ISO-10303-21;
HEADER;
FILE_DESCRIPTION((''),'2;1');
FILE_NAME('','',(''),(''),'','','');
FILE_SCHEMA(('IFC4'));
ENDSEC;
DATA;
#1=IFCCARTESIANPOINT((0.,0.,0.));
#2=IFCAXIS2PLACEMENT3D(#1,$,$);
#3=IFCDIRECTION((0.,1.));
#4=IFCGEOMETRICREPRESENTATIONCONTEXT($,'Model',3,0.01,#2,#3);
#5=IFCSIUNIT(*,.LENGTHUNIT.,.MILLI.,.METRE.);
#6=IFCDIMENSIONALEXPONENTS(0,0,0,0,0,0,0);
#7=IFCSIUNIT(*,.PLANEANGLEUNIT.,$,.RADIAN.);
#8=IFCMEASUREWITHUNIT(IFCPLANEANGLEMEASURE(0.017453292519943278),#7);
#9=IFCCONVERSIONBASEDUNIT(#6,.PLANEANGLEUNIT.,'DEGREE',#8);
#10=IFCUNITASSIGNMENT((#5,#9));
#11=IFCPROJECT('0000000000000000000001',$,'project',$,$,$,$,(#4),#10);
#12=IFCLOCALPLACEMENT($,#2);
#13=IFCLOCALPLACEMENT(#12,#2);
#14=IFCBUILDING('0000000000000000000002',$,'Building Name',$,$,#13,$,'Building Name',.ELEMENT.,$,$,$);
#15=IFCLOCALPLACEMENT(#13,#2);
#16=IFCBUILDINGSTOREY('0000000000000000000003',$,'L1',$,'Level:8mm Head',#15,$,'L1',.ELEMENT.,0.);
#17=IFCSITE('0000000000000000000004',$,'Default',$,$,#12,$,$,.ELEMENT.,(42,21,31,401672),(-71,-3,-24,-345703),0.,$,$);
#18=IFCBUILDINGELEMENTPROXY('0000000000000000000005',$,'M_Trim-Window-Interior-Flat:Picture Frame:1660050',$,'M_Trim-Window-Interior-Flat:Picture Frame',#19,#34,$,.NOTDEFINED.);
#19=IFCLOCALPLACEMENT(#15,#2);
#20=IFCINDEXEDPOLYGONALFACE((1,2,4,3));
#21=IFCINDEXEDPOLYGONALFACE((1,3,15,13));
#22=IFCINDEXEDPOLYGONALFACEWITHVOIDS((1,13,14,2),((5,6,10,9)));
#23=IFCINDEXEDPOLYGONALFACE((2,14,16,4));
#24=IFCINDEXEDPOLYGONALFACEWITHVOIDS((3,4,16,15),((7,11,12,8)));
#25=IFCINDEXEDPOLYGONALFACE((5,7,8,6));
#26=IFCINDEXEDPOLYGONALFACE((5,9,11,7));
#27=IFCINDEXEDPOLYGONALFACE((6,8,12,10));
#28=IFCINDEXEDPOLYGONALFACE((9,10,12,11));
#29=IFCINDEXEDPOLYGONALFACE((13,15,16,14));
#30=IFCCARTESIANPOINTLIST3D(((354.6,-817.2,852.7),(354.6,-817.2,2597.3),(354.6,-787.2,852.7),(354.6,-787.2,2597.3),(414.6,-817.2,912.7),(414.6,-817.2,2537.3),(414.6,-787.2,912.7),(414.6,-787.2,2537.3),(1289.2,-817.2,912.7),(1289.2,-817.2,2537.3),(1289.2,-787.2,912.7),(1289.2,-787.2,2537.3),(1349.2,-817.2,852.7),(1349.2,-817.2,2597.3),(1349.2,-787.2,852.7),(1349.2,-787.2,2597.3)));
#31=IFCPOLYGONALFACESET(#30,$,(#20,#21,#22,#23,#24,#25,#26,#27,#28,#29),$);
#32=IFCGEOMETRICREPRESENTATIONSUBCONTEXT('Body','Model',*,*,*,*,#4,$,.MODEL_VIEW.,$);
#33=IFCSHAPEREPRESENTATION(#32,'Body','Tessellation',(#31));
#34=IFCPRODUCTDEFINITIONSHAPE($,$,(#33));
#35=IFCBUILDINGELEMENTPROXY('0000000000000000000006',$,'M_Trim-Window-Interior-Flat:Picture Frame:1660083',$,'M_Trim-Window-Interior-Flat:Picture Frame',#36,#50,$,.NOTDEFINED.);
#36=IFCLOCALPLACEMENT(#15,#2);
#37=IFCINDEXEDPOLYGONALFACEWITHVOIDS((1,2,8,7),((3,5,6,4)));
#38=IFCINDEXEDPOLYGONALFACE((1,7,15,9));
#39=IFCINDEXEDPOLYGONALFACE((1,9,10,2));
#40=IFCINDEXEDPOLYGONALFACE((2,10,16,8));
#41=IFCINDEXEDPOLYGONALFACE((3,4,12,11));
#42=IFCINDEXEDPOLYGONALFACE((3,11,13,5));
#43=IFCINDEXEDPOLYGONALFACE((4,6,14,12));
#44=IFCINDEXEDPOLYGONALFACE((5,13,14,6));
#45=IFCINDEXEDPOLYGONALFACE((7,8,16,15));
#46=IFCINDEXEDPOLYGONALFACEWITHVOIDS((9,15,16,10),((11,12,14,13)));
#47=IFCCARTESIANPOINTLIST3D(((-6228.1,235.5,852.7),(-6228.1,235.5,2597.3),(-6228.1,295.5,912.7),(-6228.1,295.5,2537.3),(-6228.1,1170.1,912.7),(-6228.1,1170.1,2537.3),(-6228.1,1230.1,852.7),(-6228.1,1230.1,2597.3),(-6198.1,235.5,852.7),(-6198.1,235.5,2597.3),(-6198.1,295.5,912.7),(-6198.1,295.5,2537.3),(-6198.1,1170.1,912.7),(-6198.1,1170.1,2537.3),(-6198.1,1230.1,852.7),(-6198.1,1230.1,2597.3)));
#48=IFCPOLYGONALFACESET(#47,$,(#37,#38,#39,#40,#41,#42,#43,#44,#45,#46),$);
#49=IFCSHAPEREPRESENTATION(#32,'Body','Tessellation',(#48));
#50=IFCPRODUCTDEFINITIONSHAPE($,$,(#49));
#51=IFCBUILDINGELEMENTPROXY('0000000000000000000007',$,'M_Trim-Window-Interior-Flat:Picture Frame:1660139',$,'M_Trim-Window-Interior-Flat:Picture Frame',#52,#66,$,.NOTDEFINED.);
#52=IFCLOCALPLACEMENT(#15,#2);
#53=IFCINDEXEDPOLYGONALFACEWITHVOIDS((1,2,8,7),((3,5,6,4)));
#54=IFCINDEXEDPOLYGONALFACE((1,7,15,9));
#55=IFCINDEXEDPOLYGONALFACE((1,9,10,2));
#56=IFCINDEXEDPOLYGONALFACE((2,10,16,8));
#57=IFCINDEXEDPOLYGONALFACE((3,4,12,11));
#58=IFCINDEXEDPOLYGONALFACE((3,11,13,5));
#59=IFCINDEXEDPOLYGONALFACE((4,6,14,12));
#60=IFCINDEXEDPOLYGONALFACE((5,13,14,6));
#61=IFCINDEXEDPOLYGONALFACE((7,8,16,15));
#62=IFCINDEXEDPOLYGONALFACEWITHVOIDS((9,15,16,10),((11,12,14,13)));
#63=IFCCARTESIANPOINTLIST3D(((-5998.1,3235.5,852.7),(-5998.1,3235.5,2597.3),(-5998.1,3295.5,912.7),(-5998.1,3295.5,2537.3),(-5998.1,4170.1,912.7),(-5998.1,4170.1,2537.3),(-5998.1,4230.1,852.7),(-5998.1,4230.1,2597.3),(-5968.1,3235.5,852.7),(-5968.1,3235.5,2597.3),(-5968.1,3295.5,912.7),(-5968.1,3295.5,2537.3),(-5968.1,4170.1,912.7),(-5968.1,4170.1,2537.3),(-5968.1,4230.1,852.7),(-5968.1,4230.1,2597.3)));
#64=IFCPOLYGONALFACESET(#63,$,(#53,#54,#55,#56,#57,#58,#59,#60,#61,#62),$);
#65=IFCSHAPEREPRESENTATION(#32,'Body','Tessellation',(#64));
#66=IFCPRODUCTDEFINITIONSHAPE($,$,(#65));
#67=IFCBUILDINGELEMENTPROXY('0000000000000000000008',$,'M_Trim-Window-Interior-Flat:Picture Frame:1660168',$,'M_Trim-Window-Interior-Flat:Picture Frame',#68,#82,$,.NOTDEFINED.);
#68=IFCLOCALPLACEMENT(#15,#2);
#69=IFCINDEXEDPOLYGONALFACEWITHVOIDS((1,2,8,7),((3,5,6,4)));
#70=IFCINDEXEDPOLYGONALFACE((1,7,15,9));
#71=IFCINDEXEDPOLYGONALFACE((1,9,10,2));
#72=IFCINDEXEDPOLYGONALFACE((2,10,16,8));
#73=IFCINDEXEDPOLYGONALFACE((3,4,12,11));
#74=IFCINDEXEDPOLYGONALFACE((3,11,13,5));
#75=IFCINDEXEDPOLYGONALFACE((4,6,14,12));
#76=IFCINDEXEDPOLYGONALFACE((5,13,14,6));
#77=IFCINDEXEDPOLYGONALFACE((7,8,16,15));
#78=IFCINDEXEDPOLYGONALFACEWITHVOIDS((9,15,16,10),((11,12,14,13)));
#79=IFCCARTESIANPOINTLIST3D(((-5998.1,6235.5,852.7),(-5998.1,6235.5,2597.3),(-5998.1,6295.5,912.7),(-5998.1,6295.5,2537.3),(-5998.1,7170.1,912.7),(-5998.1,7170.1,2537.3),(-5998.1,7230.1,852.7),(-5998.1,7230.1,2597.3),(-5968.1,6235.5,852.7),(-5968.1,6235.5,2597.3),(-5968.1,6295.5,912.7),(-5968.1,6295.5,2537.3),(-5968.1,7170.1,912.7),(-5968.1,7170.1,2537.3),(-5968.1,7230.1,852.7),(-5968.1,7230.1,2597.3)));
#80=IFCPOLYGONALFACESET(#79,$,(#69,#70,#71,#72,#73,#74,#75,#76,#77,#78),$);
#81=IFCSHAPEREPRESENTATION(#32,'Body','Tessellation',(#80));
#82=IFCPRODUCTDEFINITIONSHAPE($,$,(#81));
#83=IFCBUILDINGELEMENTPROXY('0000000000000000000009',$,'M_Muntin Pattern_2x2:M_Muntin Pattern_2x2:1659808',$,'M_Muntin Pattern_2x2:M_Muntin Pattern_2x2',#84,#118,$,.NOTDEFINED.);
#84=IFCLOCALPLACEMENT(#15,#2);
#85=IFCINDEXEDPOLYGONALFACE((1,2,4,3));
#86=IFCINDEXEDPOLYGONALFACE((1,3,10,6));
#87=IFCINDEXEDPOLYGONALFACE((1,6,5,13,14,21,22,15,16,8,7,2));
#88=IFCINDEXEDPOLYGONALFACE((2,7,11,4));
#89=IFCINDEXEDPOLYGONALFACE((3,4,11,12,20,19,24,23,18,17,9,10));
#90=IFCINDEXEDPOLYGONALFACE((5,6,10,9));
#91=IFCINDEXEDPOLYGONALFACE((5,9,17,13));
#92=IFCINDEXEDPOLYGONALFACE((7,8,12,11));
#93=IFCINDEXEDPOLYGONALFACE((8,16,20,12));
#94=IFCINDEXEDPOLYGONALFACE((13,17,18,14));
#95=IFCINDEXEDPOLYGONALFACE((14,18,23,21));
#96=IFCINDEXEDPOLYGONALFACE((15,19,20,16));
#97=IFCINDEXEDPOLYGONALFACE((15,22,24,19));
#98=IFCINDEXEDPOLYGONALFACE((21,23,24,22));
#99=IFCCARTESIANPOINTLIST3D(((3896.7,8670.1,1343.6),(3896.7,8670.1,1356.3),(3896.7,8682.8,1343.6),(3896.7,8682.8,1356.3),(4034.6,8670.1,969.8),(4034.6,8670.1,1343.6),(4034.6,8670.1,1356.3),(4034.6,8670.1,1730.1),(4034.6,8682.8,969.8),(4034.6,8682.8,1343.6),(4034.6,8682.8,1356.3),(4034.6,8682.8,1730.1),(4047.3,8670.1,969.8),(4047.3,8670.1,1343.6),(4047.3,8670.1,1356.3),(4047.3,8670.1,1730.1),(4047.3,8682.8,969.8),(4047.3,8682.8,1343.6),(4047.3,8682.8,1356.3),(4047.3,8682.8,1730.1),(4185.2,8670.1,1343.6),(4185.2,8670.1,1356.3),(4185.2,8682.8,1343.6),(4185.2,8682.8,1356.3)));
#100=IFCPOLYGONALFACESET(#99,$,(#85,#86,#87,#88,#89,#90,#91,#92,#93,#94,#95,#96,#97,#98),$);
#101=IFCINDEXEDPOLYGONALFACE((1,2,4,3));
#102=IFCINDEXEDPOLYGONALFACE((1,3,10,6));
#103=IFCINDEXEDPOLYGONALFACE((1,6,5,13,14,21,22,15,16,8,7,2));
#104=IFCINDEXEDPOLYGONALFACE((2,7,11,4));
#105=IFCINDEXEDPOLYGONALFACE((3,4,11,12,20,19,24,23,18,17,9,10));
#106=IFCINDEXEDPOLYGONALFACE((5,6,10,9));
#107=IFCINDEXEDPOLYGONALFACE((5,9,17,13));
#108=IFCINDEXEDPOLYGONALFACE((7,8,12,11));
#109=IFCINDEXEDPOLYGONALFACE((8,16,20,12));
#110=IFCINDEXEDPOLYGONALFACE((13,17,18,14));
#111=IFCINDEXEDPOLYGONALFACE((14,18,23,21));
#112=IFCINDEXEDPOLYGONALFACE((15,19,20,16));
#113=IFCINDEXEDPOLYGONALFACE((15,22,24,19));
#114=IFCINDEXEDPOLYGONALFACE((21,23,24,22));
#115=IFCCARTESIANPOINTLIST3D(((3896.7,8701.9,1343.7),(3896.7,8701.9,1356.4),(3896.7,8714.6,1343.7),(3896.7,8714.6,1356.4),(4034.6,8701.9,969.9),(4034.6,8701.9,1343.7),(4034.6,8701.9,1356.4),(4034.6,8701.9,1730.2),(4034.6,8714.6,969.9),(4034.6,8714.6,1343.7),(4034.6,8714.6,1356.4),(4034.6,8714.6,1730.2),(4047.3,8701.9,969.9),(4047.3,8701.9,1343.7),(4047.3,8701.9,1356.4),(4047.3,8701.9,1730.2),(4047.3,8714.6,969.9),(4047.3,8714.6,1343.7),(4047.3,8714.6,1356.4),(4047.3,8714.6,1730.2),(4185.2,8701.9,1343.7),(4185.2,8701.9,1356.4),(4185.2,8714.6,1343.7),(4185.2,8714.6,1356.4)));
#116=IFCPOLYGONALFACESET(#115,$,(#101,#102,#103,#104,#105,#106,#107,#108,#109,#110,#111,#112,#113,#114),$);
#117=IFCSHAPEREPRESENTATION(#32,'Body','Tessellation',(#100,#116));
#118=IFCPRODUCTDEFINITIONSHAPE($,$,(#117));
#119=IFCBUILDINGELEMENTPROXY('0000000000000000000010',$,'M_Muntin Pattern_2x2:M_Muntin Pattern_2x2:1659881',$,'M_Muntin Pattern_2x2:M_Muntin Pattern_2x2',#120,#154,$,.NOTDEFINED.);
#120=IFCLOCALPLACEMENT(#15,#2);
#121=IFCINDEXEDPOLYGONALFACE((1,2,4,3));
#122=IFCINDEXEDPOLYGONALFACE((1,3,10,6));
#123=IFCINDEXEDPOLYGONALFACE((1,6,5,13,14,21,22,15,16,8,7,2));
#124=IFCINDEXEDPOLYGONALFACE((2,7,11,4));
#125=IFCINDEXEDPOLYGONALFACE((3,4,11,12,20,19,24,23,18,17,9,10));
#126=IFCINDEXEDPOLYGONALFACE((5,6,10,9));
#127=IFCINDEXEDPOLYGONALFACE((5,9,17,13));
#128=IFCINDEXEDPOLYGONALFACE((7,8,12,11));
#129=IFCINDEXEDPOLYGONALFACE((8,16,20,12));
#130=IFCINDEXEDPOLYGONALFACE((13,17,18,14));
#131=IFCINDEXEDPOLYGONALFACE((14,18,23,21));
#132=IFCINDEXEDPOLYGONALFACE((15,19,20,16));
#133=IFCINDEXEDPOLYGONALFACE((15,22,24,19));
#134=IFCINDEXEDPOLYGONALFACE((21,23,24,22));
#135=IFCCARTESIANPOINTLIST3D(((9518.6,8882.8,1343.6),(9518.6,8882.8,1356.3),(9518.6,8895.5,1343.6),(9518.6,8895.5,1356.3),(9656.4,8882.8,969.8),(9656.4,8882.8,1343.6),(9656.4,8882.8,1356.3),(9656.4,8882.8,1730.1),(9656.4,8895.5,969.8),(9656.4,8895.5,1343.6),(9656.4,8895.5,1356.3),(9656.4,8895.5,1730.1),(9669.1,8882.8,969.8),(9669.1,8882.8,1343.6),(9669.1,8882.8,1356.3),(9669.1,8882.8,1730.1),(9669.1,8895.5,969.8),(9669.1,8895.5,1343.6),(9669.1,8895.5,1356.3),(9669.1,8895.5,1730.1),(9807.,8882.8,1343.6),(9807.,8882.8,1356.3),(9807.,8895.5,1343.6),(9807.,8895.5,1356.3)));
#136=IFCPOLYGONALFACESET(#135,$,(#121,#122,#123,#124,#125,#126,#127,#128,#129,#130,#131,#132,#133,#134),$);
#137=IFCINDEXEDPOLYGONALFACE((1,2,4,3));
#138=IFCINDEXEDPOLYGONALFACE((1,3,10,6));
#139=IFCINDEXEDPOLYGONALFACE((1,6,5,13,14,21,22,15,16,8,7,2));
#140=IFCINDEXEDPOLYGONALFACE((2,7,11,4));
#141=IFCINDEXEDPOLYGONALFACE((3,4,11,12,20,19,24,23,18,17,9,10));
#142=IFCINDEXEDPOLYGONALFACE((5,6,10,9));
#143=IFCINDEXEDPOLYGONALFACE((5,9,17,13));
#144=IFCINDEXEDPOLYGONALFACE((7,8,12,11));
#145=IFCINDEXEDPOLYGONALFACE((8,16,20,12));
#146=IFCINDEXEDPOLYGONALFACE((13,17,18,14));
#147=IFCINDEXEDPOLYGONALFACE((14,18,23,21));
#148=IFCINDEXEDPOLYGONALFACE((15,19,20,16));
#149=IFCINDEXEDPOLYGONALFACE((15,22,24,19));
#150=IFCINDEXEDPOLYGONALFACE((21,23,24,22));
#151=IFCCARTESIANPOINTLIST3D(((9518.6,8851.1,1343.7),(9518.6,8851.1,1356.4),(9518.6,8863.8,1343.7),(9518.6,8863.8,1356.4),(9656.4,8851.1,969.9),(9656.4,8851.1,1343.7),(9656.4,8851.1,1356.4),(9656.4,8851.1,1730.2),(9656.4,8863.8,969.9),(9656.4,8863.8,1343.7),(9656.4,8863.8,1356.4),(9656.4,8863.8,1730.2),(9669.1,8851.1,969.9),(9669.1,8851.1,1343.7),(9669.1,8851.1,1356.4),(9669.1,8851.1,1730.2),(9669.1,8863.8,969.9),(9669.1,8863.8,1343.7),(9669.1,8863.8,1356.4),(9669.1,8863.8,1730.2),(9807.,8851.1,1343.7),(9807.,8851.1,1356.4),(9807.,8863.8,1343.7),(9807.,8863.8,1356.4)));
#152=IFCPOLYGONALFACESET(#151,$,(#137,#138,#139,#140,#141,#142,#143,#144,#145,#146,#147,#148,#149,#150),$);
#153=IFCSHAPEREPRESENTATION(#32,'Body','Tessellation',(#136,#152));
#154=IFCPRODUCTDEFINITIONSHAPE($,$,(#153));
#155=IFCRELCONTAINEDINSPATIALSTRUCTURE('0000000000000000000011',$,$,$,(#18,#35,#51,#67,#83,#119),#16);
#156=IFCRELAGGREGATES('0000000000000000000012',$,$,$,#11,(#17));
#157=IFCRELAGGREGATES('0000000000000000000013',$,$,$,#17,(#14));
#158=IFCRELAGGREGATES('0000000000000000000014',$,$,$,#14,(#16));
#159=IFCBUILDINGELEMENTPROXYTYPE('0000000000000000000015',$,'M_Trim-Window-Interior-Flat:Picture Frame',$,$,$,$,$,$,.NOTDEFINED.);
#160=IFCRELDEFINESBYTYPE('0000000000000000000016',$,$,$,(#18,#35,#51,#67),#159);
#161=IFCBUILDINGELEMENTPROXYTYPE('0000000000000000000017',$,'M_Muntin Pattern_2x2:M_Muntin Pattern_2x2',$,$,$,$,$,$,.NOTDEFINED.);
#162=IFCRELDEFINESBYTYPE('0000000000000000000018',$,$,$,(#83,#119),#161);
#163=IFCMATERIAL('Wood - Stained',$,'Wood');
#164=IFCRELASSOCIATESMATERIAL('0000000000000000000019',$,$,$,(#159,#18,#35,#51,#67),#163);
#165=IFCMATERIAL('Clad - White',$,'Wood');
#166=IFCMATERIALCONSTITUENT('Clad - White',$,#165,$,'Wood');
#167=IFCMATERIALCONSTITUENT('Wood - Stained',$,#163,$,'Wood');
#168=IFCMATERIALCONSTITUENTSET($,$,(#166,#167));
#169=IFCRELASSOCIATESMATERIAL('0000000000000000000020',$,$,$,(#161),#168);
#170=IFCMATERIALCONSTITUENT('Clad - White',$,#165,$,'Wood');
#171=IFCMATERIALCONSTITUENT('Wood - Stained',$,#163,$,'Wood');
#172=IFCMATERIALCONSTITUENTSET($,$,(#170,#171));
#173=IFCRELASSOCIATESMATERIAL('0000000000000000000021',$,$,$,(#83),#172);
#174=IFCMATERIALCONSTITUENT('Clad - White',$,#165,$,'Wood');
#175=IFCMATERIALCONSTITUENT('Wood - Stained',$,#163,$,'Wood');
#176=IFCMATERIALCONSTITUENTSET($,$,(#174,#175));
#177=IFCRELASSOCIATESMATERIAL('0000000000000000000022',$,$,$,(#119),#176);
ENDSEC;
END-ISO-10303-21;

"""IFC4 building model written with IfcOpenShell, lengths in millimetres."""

from ifc_helpers import new_model, entity, si_unit, converted_unit, direction, frame, origin, place, context, subcontext, project, spatial, indexed_curve, outline, extrude, source, transform, mapped, material, constituent, constituent_set, type_object, type_shapes, element, save


model = new_model("IFC4")

# Units and contexts
model_context = context("Model", 3, precision=0.01, world=origin(), true_north=direction((0.0, 1.0)))
body_context = subcontext(model_context, "Body", "Model", "MODEL_VIEW")
ifc_project = project(units=[si_unit("LENGTHUNIT", "METRE", prefix="MILLI"), converted_unit("PLANEANGLEUNIT", "DEGREE", entity("IfcPlaneAngleMeasure", 0.017453292519943278), si_unit("PLANEANGLEUNIT", "RADIAN"), dimensions=[0, 0, 0, 0, 0, 0, 0])], contexts=[model_context])

# Site, building, storey
site_placement = place(None, origin())
site = spatial("IfcSite", under=ifc_project, at=site_placement, Name="Default", CompositionType="ELEMENT", RefLatitude=(42, 21, 31, 401672), RefLongitude=(-71, -3, -24, -345703), RefElevation=0.0)
building_placement = place(site_placement, origin())
building = spatial("IfcBuilding", under=site, at=building_placement, Name="Building Name", LongName="Building Name", CompositionType="ELEMENT")
storey_placement = place(building_placement, origin())
storey = spatial("IfcBuildingStorey", under=building, at=storey_placement, Name="L1", ObjectType="Level:8mm Head", LongName="L1", CompositionType="ELEMENT", Elevation=0.0)

# Building element proxies
ifc_material_1 = material(Name="Clad - White", Category="Wood")
ifc_material_2 = material(Name="Wood - Stained", Category="Wood")
building_element_proxy_type_1 = type_object("IfcBuildingElementProxyType", Name="M_Trim-Window-Interior-Flat:Picture Frame", PredefinedType="NOTDEFINED", material=ifc_material_2)
shared_shape_1 = source(origin(), body_context, "Body", "SweptSolid", [
    extrude(outline(indexed_curve([(-497.3, -872.3), (497.3, -872.3), (497.3, 872.3), (-497.3, 872.3), (-497.3, -872.3)], self_intersect=False), holes=[indexed_curve([(-437.3, -812.3), (-437.3, 812.3), (437.3, 812.3), (437.3, -812.3), (-437.3, -812.3)], self_intersect=False)]), frame((0.0, -825.0, 0.0), z_axis=(0.0, 0.0, 1.0), x_axis=(-1.0, 0.0, 0.0)), (0.0, 0.0, 1.0), 30.0),
])
type_shapes(building_element_proxy_type_1, [shared_shape_1])
for number, where, z_axis, x_axis, name in (
    (1, (851.9, -817.2, 2550.0), (0.0, 1.0, 0.0), (-1.0, 0.0, 0.0), "M_Trim-Window-Interior-Flat:Picture Frame:1660050"),
    (2, (-6198.1, 732.8, 2550.0), (-1.0, 0.0, 0.0), (0.0, -1.0, 0.0), "M_Trim-Window-Interior-Flat:Picture Frame:1660083"),
    (3, (-5998.1, 3732.8, 2550.0), (1.0, 0.0, 0.0), (0.0, 1.0, 0.0), "M_Trim-Window-Interior-Flat:Picture Frame:1660139"),
    (4, (-5998.1, 6732.8, 2550.0), (1.0, 0.0, 0.0), (0.0, 1.0, 0.0), "M_Trim-Window-Interior-Flat:Picture Frame:1660168"),
):
    element("IfcBuildingElementProxy", number, at=place(storey_placement, frame(where, z_axis=z_axis, x_axis=x_axis)), inside=storey, type_object=building_element_proxy_type_1, material=ifc_material_2, Name=name, ObjectType="M_Trim-Window-Interior-Flat:Picture Frame", PredefinedType="NOTDEFINED", context=body_context, shape_type="MappedRepresentation", body=[
        mapped(shared_shape_1, transform((0.0, 0.0, 0.0), scale=1.0)),
    ])
ifc_constituent_1 = constituent(ifc_material_1, Name="Clad - White", Category="Wood")
ifc_constituent_2 = constituent(ifc_material_2, Name="Wood - Stained", Category="Wood")
ifc_constituent_set_1 = constituent_set(constituents=[ifc_constituent_1, ifc_constituent_2])
ifc_constituent_3 = constituent(ifc_material_1, Name="Clad - White", Category="Wood")
ifc_constituent_4 = constituent(ifc_material_2, Name="Wood - Stained", Category="Wood")
ifc_constituent_set_2 = constituent_set(constituents=[ifc_constituent_3, ifc_constituent_4])
building_element_proxy_type_2 = type_object("IfcBuildingElementProxyType", Name="M_Muntin Pattern_2x2:M_Muntin Pattern_2x2", PredefinedType="NOTDEFINED", material=ifc_constituent_set_2)
shared_shape_2 = source(origin(), body_context, "Body", "SweptSolid", [
    extrude(outline(indexed_curve([(6.4, -6.4), (380.1, -6.4), (380.1, 6.3), (6.4, 6.3), (6.4, 144.2), (-6.3, 144.2), (-6.3, 6.3), (-380.2, 6.3), (-380.2, -6.4), (-6.3, -6.4), (-6.3, -144.2), (6.4, -144.2), (6.4, -6.4)], self_intersect=False)), frame((0.0, -22.2, 380.1), z_axis=(0.0, 1.0, 0.0), x_axis=(0.0, 0.0, 1.0)), (0.0, 0.0, 1.0), 12.7),
    extrude(outline(indexed_curve([(6.4, -6.4), (380.2, -6.4), (380.2, 6.3), (6.4, 6.3), (6.4, 144.2), (-6.3, 144.2), (-6.3, 6.3), (-380.2, 6.3), (-380.2, -6.4), (-6.3, -6.4), (-6.3, -144.2), (6.4, -144.2), (6.4, -6.4)], self_intersect=False)), frame((0.0, 9.5, 380.2), z_axis=(0.0, 1.0, 0.0), x_axis=(0.0, 0.0, 1.0)), (0.0, 0.0, 1.0), 12.7),
])
type_shapes(building_element_proxy_type_2, [shared_shape_2])
proxy_1_placement = place(storey_placement, frame((4041.0, 8692.3, 969.9)))
element("IfcBuildingElementProxy", 5, at=proxy_1_placement, inside=storey, type_object=building_element_proxy_type_2, material=ifc_constituent_set_1, Name="M_Muntin Pattern_2x2:M_Muntin Pattern_2x2:1659808", ObjectType="M_Muntin Pattern_2x2:M_Muntin Pattern_2x2", PredefinedType="NOTDEFINED", context=body_context, shape_type="MappedRepresentation", body=[
    mapped(shared_shape_2, transform((0.0, 0.0, 0.0), scale=1.0)),
])
ifc_constituent_5 = constituent(ifc_material_1, Name="Clad - White", Category="Wood")
ifc_constituent_6 = constituent(ifc_material_2, Name="Wood - Stained", Category="Wood")
ifc_constituent_set_3 = constituent_set(constituents=[ifc_constituent_5, ifc_constituent_6])
proxy_2_placement = place(storey_placement, frame((9662.8, 8873.3, 969.9), z_axis=(0.0, 0.0, 1.0), x_axis=(-1.0, 0.0, 0.0)))
element("IfcBuildingElementProxy", 6, at=proxy_2_placement, inside=storey, type_object=building_element_proxy_type_2, material=ifc_constituent_set_3, Name="M_Muntin Pattern_2x2:M_Muntin Pattern_2x2:1659881", ObjectType="M_Muntin Pattern_2x2:M_Muntin Pattern_2x2", PredefinedType="NOTDEFINED", context=body_context, shape_type="MappedRepresentation", body=[
    mapped(shared_shape_2, transform((0.0, 0.0, 0.0), scale=1.0)),
])

save(model, "model.ifc")
